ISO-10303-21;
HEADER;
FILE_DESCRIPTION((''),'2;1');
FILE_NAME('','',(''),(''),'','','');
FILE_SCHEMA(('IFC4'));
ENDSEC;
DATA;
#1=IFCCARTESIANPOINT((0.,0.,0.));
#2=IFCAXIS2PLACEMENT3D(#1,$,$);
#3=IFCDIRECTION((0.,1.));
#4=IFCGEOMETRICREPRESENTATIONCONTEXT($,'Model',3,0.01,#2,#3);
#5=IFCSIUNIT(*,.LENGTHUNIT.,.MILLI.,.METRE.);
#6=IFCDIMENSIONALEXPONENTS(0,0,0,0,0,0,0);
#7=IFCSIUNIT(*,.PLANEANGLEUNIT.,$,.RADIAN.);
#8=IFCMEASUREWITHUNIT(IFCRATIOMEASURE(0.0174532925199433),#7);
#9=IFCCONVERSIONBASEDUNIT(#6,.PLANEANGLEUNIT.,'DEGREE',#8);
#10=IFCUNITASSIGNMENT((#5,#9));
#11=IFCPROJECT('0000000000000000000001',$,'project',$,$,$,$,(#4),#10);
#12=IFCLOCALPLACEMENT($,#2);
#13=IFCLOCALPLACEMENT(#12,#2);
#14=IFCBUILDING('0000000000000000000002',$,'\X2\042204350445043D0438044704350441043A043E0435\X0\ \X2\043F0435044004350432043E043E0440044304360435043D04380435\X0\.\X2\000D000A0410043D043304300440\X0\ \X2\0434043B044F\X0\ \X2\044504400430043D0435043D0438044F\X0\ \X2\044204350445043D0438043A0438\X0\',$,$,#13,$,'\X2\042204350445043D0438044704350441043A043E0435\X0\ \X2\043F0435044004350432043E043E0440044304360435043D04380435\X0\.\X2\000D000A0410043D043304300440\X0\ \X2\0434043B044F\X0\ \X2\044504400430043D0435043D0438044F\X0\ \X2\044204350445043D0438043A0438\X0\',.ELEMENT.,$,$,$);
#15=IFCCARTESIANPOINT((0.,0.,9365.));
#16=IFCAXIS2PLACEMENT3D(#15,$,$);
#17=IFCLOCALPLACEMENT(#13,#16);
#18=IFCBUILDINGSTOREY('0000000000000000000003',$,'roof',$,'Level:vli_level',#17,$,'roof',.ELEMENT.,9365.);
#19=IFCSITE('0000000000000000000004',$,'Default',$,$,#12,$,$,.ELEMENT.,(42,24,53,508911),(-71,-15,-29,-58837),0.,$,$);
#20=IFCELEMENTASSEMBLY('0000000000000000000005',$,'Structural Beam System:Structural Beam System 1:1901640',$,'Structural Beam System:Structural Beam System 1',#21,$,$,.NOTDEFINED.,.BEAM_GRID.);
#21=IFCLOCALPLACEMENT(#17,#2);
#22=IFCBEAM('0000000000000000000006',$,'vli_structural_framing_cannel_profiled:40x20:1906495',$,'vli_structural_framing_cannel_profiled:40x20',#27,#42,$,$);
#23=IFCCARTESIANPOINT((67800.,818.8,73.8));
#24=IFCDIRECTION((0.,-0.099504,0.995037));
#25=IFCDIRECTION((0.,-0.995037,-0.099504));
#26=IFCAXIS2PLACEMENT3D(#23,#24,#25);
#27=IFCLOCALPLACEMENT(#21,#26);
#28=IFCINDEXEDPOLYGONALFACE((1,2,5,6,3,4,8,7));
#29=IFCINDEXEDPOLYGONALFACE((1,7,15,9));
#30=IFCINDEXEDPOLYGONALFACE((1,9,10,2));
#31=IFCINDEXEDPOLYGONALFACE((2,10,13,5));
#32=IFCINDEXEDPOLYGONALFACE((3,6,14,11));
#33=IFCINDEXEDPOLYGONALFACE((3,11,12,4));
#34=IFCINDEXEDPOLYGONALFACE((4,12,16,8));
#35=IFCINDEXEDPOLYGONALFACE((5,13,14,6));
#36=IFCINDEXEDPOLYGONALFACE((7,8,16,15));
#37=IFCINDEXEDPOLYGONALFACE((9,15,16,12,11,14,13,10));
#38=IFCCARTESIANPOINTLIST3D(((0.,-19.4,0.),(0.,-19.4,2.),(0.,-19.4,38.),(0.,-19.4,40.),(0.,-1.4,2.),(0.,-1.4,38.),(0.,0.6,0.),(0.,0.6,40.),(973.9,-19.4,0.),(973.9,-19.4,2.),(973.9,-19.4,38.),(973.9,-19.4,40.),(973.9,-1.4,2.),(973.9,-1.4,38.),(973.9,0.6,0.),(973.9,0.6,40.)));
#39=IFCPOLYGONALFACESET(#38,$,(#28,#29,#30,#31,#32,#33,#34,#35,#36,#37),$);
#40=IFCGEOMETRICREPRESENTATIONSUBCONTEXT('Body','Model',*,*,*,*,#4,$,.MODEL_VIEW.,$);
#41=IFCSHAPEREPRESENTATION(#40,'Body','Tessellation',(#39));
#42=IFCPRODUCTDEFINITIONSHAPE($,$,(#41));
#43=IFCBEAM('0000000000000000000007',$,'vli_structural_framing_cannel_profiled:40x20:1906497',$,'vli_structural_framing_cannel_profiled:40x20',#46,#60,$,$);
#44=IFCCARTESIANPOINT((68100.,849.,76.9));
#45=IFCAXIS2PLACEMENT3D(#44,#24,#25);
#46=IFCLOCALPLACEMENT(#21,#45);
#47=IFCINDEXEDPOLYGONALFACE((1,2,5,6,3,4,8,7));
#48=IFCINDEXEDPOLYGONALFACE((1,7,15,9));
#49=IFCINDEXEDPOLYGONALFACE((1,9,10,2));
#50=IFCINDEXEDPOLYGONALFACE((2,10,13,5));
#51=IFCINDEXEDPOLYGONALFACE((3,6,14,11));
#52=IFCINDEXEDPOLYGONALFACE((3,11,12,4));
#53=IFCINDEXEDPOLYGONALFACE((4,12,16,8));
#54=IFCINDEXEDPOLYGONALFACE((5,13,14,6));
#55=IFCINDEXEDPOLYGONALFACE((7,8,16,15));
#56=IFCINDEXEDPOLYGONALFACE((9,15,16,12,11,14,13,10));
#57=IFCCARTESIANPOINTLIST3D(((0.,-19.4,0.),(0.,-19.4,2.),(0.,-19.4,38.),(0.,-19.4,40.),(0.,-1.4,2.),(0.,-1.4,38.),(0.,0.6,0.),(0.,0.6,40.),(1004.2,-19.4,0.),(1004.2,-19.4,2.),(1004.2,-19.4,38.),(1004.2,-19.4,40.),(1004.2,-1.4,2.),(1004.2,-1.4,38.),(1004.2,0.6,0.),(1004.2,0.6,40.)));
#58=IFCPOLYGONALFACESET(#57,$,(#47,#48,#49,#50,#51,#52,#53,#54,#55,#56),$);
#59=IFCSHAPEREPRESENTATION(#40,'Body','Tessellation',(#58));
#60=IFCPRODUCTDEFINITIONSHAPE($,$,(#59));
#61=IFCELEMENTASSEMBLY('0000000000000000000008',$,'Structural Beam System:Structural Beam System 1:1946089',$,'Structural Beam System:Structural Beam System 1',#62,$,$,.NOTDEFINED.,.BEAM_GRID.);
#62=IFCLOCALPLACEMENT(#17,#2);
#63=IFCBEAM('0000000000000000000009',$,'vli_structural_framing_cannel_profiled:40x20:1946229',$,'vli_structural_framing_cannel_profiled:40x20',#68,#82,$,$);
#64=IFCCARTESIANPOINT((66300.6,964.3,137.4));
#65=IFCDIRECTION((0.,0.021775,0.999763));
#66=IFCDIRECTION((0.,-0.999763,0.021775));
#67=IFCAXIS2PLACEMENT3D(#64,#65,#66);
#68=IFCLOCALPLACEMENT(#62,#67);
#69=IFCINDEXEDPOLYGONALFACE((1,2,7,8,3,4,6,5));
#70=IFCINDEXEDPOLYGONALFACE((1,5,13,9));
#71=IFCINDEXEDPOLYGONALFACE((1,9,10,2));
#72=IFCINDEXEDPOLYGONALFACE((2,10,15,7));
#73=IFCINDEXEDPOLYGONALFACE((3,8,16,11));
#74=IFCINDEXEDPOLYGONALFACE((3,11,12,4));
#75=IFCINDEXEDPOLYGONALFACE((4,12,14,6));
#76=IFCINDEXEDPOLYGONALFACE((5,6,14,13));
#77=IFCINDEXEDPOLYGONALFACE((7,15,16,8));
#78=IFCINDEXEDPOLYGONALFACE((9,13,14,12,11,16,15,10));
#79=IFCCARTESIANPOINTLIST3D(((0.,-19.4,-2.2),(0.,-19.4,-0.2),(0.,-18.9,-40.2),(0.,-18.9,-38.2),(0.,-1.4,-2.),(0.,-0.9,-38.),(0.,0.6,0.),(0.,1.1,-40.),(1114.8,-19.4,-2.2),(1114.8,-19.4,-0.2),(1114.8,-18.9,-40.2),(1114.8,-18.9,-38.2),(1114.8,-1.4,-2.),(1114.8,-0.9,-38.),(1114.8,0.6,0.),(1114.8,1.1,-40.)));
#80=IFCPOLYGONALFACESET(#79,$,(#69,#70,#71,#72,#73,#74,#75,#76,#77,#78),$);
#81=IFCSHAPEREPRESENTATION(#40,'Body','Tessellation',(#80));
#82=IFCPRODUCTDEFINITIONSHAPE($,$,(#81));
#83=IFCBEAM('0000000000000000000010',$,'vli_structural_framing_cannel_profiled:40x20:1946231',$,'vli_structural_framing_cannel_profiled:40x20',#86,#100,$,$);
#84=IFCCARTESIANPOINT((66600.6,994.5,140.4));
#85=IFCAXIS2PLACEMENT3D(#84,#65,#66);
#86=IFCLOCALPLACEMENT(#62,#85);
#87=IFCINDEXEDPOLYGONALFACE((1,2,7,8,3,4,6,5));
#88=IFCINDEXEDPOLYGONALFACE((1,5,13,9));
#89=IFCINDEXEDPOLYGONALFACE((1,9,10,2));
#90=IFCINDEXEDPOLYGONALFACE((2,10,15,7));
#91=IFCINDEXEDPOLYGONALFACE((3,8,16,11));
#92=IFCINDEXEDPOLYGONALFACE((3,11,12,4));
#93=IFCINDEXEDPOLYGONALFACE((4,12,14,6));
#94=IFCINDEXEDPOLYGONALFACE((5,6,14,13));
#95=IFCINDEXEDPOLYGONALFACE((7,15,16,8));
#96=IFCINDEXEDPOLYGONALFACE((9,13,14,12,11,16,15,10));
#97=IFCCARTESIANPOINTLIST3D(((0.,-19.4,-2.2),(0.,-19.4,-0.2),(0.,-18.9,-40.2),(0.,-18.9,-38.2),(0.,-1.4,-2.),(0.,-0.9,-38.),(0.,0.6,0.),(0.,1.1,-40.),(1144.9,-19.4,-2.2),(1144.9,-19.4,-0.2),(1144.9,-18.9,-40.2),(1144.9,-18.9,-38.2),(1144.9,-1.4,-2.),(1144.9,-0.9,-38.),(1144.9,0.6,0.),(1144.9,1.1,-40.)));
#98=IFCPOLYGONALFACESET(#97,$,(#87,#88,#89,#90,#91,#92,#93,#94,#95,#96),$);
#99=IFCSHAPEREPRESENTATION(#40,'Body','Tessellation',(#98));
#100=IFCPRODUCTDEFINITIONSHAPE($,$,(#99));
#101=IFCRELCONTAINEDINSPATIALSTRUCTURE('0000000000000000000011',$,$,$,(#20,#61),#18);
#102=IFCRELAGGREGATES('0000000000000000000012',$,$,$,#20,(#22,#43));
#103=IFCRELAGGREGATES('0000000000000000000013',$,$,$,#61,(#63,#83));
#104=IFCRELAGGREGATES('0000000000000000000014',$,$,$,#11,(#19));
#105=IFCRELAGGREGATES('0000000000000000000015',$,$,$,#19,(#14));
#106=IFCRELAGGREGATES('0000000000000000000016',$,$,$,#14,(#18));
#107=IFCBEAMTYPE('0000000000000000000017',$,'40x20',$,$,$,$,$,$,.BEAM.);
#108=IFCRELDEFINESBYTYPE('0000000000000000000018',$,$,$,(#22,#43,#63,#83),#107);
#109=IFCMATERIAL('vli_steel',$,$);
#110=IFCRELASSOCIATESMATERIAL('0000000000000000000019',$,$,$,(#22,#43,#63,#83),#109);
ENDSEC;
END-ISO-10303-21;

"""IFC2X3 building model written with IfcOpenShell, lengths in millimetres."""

from ifc_helpers import new_model, entity, si_unit, converted_unit, direction, frame, origin, place, context, subcontext, project, spatial, polyline, outline, extrude, material, type_object, element, aggregate, save


model = new_model("IFC2X3")

# Units and contexts
model_context = context("Model", 3, precision=0.01, world=origin(), true_north=direction((0.0, 1.0)))
body_context = subcontext(model_context, "Body", "Model", "MODEL_VIEW")
ifc_project = project(units=[si_unit("LENGTHUNIT", "METRE", prefix="MILLI"), converted_unit("PLANEANGLEUNIT", "DEGREE", entity("IfcRatioMeasure", 0.0174532925199433), si_unit("PLANEANGLEUNIT", "RADIAN"), dimensions=[0, 0, 0, 0, 0, 0, 0])], contexts=[model_context])

# Site, building, storey
site_placement = place(None, origin())
site = spatial("IfcSite", under=ifc_project, at=site_placement, Name="Default", CompositionType="ELEMENT", RefLatitude=(42, 24, 53, 508911), RefLongitude=(-71, -15, -29, -58837), RefElevation=0.0)
building_placement = place(site_placement, origin())
building = spatial("IfcBuilding", under=site, at=building_placement, Name="Техническое перевооружение.\r\nАнгар для хранения техники", LongName="Техническое перевооружение.\r\nАнгар для хранения техники", CompositionType="ELEMENT")
storey_placement = place(building_placement, frame((0.0, 0.0, 9365.0)))
storey = spatial("IfcBuildingStorey", under=building, at=storey_placement, Name="roof", ObjectType="Level:vli_level", LongName="roof", CompositionType="ELEMENT", Elevation=9365.0)

# Element assemblies, beams
assembly_1_placement = place(storey_placement, origin())
assembly_1 = element("IfcElementAssembly", 1, at=assembly_1_placement, inside=storey, Name="Structural Beam System:Structural Beam System 1:1901640", ObjectType="Structural Beam System:Structural Beam System 1", AssemblyPlace="NOTDEFINED", PredefinedType="BEAM_GRID")
ifc_material = material(Name="vli_steel")
beam_type = type_object("IfcBeamType", Name="40x20", PredefinedType="BEAM")
beam_1_placement = place(assembly_1_placement, frame((67800.0, 818.8, 73.8), z_axis=(0.0, -0.099504, 0.995037), x_axis=(0.0, -0.995037, -0.099504)))
beam_1 = element("IfcBeam", 2, at=beam_1_placement, type_object=beam_type, material=ifc_material, Name="vli_structural_framing_cannel_profiled:40x20:1906495", ObjectType="vli_structural_framing_cannel_profiled:40x20", context=body_context, shape_type="SweptSolid", body=[
    extrude(outline(polyline([(-20.0, -9.5), (-18.0, -9.5), (-18.0, 8.5), (18.0, 8.5), (18.0, -9.5), (20.0, -9.5), (20.0, 10.5), (-20.0, 10.5), (-20.0, -9.5)])), frame((0.0, -9.9, 20.0), z_axis=(1.0, 0.0, 0.0), x_axis=(0.0, 0.0, -1.0)), (0.0, 0.0, 1.0), 973.9),
])
beam_2_placement = place(assembly_1_placement, frame((68100.0, 849.0, 76.9), z_axis=(0.0, -0.099504, 0.995037), x_axis=(0.0, -0.995037, -0.099504)))
beam_2 = element("IfcBeam", 3, at=beam_2_placement, type_object=beam_type, material=ifc_material, Name="vli_structural_framing_cannel_profiled:40x20:1906497", ObjectType="vli_structural_framing_cannel_profiled:40x20", context=body_context, shape_type="SweptSolid", body=[
    extrude(outline(polyline([(-20.0, -9.5), (-18.0, -9.5), (-18.0, 8.5), (18.0, 8.5), (18.0, -9.5), (20.0, -9.5), (20.0, 10.5), (-20.0, 10.5), (-20.0, -9.5)])), frame((0.0, -9.9, 20.0), z_axis=(1.0, 0.0, 0.0), x_axis=(0.0, 0.0, -1.0)), (0.0, 0.0, 1.0), 1004.2),
])
aggregate(assembly_1, [beam_1, beam_2])
assembly_2_placement = place(storey_placement, origin())
assembly_2 = element("IfcElementAssembly", 4, at=assembly_2_placement, inside=storey, Name="Structural Beam System:Structural Beam System 1:1946089", ObjectType="Structural Beam System:Structural Beam System 1", AssemblyPlace="NOTDEFINED", PredefinedType="BEAM_GRID")
beam_3_placement = place(assembly_2_placement, frame((66300.6, 964.3, 137.4), z_axis=(0.0, 0.021775, 0.999763), x_axis=(0.0, -0.999763, 0.021775)))
beam_3 = element("IfcBeam", 5, at=beam_3_placement, type_object=beam_type, material=ifc_material, Name="vli_structural_framing_cannel_profiled:40x20:1946229", ObjectType="vli_structural_framing_cannel_profiled:40x20", context=body_context, shape_type="SweptSolid", body=[
    extrude(outline(polyline([(-10.5, -20.0), (9.5, -20.0), (9.5, -18.0), (-8.5, -18.0), (-8.5, 18.0), (9.5, 18.0), (9.5, 20.0), (-10.5, 20.0), (-10.5, -20.0)])), frame((0.0, -9.7, -20.1), z_axis=(1.0, 0.0, 0.0), x_axis=(0.0, -0.999925, -0.01227)), (0.0, 0.0, 1.0), 1114.8),
])
beam_4_placement = place(assembly_2_placement, frame((66600.6, 994.5, 140.4), z_axis=(0.0, 0.021775, 0.999763), x_axis=(0.0, -0.999763, 0.021775)))
beam_4 = element("IfcBeam", 6, at=beam_4_placement, type_object=beam_type, material=ifc_material, Name="vli_structural_framing_cannel_profiled:40x20:1946231", ObjectType="vli_structural_framing_cannel_profiled:40x20", context=body_context, shape_type="SweptSolid", body=[
    extrude(outline(polyline([(-10.5, -20.0), (9.5, -20.0), (9.5, -18.0), (-8.5, -18.0), (-8.5, 18.0), (9.5, 18.0), (9.5, 20.0), (-10.5, 20.0), (-10.5, -20.0)])), frame((0.0, -9.7, -20.1), z_axis=(1.0, 0.0, 0.0), x_axis=(0.0, -0.999925, -0.01227)), (0.0, 0.0, 1.0), 1144.9),
])
aggregate(assembly_2, [beam_3, beam_4])

save(model, "model.ifc")
